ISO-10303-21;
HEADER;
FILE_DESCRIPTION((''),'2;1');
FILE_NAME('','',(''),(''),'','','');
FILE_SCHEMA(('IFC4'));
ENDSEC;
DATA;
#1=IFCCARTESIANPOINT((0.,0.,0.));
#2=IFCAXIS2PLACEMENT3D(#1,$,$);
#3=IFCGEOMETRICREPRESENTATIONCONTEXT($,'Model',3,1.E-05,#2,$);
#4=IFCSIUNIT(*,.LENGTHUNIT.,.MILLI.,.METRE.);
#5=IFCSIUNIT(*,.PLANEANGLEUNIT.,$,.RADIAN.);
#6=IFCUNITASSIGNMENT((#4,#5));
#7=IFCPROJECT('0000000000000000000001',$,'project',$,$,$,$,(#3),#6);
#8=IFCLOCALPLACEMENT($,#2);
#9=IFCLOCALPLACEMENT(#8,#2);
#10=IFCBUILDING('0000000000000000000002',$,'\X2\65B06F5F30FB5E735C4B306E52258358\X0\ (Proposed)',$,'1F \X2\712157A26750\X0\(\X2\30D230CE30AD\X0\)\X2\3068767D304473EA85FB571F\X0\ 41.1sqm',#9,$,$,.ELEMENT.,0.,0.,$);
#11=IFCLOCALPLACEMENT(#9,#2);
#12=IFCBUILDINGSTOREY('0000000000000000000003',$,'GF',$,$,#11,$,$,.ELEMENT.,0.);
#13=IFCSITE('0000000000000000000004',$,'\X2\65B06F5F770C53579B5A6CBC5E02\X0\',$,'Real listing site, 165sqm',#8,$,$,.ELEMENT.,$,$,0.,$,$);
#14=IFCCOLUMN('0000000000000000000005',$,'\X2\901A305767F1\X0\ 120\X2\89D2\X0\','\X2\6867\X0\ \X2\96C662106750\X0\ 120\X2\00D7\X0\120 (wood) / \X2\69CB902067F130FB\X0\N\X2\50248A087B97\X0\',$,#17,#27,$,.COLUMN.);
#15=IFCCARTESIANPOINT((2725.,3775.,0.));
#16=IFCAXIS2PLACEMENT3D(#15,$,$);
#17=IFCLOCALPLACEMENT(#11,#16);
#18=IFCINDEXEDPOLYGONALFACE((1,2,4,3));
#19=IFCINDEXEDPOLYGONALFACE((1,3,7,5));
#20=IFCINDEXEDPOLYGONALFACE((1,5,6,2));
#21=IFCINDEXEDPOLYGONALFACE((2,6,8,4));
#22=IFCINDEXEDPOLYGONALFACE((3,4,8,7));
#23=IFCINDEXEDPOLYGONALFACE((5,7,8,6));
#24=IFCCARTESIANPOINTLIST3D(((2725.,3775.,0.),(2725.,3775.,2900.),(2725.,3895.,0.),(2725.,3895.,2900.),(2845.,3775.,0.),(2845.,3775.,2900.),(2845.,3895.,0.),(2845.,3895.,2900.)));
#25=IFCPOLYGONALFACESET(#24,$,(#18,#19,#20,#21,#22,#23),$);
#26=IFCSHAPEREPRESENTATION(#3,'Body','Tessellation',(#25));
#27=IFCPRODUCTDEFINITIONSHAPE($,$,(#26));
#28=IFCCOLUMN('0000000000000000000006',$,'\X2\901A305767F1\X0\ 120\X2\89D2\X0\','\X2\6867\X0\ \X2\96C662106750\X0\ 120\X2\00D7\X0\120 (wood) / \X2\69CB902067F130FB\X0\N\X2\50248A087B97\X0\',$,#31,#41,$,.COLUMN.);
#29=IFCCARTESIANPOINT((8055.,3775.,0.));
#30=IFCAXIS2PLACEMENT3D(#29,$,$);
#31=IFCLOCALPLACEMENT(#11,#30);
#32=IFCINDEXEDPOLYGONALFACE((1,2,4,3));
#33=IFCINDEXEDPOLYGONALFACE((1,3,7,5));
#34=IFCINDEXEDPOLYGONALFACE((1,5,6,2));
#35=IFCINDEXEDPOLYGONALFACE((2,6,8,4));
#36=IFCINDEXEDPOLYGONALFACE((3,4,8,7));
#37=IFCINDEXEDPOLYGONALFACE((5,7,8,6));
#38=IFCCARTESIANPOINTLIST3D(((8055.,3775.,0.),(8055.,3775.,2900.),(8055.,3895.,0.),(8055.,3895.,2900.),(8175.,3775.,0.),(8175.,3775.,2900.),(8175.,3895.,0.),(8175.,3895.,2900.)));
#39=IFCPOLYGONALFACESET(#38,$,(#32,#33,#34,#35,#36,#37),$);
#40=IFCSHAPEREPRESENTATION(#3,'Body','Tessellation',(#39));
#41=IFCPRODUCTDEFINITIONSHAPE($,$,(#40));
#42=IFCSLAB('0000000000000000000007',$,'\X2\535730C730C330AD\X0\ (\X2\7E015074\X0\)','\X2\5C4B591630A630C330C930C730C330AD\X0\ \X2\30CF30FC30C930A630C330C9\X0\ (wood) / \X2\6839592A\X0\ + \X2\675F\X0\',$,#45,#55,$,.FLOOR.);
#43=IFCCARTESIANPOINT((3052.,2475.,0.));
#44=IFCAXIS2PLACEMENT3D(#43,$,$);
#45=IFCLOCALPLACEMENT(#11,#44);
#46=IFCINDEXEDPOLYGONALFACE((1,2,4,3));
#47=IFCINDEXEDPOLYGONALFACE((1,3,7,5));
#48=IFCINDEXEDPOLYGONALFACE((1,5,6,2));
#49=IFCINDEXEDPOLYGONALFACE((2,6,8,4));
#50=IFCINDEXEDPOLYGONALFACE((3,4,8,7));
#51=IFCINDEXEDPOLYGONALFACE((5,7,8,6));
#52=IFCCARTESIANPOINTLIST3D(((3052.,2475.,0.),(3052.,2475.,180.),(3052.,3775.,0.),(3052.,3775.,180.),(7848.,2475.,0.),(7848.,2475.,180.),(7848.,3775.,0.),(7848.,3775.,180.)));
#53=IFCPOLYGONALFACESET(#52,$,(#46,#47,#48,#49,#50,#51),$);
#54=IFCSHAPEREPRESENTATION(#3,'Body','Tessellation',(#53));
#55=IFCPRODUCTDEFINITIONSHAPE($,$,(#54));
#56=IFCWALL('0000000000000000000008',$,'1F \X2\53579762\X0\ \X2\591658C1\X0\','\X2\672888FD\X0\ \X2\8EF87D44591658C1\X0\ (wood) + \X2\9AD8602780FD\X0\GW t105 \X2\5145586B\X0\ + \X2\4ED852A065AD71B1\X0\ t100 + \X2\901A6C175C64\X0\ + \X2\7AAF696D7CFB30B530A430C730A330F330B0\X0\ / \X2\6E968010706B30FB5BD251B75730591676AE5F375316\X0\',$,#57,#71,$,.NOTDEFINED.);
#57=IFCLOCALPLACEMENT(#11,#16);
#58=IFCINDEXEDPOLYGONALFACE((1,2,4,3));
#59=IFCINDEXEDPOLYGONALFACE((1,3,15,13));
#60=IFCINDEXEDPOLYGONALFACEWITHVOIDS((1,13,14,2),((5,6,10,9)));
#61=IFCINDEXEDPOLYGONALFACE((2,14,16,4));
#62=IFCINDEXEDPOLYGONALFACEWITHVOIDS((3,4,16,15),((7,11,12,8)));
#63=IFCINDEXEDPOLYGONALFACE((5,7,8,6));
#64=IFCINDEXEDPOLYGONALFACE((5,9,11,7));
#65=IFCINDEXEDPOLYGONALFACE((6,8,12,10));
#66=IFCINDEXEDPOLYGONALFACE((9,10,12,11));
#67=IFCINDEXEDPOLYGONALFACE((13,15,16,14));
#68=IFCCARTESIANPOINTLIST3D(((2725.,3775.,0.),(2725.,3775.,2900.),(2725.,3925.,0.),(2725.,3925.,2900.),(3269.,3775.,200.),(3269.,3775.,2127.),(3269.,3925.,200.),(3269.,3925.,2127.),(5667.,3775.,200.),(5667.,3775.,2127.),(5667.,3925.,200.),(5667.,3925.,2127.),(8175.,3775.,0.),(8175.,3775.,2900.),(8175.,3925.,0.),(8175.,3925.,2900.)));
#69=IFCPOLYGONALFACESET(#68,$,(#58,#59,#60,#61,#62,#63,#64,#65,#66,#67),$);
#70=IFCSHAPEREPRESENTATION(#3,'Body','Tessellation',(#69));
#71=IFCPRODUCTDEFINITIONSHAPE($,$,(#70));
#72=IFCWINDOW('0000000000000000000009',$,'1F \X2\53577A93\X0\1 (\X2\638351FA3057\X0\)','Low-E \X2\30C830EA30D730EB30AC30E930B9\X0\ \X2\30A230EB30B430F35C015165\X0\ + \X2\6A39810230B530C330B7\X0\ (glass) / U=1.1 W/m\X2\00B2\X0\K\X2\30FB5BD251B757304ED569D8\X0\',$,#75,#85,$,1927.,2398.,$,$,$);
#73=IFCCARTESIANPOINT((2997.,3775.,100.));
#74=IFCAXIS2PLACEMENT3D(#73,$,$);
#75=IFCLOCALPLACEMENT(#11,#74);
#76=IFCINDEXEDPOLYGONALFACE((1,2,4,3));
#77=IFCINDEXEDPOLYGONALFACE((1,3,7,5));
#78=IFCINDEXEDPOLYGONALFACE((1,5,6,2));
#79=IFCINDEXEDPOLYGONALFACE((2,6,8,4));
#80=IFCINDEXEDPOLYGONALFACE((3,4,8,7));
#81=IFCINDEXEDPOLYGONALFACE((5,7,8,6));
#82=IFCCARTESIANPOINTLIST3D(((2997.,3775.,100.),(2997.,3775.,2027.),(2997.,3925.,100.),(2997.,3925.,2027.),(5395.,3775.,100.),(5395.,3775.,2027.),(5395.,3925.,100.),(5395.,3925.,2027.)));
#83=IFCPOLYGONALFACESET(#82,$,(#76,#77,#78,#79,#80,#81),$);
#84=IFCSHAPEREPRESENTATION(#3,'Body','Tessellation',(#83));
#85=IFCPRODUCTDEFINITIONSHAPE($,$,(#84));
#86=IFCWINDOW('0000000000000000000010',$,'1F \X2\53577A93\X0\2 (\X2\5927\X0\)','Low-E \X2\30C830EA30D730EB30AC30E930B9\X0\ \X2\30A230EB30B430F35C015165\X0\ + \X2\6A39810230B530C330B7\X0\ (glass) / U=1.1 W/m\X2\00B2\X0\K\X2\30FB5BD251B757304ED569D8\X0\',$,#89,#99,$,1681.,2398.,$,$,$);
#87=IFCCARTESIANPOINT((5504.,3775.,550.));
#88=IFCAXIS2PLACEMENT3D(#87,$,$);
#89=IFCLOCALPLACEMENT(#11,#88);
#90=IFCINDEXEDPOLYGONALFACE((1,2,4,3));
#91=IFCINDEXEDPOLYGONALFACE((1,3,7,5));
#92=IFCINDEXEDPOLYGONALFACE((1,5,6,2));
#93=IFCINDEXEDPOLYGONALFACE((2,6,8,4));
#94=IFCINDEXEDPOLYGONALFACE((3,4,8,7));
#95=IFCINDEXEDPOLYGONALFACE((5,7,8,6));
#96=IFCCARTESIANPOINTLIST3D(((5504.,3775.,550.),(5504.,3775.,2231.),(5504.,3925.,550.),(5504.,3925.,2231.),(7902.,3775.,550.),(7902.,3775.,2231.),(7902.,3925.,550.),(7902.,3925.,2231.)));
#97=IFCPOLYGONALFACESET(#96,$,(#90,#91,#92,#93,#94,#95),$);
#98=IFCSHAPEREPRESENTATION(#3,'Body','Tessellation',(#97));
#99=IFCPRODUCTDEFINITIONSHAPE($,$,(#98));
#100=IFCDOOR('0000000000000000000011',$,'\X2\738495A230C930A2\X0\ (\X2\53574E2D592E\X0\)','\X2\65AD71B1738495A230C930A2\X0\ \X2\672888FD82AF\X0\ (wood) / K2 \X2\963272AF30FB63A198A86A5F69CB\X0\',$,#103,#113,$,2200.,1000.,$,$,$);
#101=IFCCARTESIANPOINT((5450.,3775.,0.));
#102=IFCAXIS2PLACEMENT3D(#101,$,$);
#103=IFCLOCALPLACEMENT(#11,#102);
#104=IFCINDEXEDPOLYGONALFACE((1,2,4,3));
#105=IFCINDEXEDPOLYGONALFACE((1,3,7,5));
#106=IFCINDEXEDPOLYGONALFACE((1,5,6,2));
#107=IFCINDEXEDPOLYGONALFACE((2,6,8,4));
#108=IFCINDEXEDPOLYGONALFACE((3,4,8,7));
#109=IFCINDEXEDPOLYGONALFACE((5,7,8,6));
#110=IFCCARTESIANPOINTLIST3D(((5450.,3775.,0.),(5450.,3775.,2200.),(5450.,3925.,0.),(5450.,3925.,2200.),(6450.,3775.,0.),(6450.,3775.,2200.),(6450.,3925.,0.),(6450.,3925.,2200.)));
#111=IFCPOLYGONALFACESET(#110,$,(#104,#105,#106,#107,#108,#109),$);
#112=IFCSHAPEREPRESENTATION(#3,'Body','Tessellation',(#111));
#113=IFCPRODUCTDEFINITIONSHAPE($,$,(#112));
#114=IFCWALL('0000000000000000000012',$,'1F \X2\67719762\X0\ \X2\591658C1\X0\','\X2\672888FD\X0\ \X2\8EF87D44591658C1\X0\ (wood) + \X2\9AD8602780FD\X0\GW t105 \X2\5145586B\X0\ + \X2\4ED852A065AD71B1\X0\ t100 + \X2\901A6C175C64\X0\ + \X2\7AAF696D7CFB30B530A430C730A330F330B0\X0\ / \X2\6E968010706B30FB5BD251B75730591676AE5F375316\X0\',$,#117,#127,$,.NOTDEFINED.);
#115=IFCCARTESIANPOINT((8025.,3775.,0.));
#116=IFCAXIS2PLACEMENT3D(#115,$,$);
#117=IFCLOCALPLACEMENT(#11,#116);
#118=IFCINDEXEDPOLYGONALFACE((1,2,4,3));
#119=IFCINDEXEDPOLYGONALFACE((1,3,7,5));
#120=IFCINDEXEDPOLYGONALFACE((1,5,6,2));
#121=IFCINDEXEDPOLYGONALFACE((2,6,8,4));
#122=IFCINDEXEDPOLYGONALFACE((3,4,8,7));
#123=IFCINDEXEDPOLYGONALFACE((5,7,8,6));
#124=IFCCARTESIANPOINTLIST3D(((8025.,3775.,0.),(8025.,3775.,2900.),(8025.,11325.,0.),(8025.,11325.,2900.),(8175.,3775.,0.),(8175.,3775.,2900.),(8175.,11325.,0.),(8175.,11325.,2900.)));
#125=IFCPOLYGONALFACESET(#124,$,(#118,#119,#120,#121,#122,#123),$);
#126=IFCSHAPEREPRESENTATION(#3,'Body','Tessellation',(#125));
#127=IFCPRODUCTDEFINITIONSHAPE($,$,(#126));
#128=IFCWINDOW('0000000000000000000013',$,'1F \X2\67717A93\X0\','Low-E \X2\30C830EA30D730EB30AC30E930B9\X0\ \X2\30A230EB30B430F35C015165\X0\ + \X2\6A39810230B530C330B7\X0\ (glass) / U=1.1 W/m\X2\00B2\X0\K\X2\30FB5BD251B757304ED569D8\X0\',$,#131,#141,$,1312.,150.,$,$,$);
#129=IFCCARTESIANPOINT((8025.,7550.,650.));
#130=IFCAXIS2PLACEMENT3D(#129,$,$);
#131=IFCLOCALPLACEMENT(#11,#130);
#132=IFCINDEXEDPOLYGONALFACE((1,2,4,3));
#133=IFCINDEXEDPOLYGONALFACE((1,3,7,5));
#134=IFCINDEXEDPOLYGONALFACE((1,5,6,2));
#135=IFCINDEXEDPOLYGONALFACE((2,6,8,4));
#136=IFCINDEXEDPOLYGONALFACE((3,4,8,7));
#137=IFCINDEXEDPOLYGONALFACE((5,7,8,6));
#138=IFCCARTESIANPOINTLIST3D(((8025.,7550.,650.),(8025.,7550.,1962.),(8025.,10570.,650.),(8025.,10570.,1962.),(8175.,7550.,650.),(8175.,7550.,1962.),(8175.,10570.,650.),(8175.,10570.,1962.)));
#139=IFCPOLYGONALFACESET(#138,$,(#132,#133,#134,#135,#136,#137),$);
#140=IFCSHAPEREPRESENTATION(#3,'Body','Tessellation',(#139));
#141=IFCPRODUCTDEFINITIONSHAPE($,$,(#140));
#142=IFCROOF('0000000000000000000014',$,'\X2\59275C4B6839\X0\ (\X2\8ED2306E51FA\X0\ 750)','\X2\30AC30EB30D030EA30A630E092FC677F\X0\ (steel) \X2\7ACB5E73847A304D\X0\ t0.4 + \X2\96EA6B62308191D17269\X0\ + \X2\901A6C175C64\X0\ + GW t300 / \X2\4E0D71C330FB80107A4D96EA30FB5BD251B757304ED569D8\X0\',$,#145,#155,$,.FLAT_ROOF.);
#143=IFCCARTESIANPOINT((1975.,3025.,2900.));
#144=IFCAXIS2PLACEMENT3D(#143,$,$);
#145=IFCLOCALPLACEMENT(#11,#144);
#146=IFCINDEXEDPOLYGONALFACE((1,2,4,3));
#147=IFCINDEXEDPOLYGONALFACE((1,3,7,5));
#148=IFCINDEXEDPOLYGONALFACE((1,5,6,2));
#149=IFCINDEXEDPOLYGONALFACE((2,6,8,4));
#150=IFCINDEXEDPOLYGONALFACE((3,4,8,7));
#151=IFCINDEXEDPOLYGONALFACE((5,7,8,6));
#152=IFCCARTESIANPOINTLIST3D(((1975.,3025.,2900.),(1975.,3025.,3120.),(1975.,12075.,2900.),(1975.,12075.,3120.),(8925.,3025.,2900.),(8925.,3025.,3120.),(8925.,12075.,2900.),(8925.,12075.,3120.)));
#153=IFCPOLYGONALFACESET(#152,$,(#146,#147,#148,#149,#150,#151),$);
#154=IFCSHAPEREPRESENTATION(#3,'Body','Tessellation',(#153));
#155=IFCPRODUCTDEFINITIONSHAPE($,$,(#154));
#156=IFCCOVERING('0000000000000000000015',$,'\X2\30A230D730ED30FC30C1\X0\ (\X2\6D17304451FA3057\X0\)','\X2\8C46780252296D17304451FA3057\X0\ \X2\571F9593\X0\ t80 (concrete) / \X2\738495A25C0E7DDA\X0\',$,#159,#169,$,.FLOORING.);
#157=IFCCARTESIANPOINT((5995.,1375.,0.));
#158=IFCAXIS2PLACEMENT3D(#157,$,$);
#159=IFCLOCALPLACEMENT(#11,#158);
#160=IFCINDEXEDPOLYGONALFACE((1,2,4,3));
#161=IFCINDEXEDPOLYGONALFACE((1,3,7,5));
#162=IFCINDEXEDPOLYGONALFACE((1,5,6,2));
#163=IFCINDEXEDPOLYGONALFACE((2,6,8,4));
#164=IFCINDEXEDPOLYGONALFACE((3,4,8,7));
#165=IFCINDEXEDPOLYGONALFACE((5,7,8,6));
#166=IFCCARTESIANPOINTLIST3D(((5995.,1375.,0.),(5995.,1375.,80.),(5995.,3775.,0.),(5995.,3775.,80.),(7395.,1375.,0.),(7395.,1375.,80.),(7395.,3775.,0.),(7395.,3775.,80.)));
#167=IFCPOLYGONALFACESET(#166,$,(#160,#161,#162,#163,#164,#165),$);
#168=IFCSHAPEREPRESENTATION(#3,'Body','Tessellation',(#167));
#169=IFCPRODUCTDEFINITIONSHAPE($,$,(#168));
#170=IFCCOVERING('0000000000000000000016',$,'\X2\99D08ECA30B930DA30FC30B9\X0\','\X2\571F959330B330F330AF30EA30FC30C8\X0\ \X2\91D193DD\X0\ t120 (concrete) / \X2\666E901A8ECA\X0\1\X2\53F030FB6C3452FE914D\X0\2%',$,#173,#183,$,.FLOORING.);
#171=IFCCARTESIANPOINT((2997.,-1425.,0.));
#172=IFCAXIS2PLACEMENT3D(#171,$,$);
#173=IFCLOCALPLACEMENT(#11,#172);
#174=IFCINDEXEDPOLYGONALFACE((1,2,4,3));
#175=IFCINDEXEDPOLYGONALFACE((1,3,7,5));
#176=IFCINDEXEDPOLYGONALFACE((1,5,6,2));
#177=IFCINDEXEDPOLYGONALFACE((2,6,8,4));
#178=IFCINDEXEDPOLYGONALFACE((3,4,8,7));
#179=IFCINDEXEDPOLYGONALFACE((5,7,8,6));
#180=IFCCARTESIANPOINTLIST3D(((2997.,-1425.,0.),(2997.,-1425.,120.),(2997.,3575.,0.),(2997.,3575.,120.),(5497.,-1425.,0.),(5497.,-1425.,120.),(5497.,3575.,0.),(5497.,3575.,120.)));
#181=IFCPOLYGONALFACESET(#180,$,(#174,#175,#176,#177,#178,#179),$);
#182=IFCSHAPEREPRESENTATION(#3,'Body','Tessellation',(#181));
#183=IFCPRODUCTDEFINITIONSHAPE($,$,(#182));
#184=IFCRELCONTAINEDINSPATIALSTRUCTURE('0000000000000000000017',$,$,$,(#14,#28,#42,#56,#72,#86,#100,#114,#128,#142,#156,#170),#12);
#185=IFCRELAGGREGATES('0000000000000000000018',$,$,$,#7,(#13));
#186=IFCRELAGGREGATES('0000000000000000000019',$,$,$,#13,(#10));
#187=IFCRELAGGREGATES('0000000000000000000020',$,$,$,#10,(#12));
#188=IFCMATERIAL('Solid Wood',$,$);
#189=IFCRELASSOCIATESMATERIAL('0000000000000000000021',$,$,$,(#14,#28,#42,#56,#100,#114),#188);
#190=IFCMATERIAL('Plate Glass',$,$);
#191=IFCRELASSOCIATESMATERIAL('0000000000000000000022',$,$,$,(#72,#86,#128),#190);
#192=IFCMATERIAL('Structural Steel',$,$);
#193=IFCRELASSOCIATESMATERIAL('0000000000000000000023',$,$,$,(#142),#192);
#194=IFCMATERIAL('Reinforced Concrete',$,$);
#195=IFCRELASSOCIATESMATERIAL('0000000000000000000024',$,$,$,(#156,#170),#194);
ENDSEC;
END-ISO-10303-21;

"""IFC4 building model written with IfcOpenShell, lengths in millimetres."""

from ifc_helpers import new_model, si_unit, frame, frame_2d, origin, place, context, project, spatial, rectangle, extrude, material, element, fill, save


model = new_model("IFC4")

# Units and contexts
model_context = context("Model", 3, precision=1e-05, world=origin())
ifc_project = project(units=[si_unit("LENGTHUNIT", "METRE", prefix="MILLI"), si_unit("PLANEANGLEUNIT", "RADIAN")], contexts=[model_context])

# Site, building, storey
site_placement = place(None, origin())
site = spatial("IfcSite", under=ifc_project, at=site_placement, Name="新潟県南魚沼市", ObjectType="Real listing site, 165sqm", CompositionType="ELEMENT", RefElevation=0.0)
building_placement = place(site_placement, origin())
building = spatial("IfcBuilding", under=site, at=building_placement, Name="新潟・平屋の別荘 (Proposed)", ObjectType="1F 無垢材(ヒノキ)と白い珪藻土 41.1sqm", CompositionType="ELEMENT", ElevationOfRefHeight=0.0, ElevationOfTerrain=0.0)
storey_placement = place(building_placement, origin())
storey = spatial("IfcBuildingStorey", under=building, at=storey_placement, Name="GF", CompositionType="ELEMENT", Elevation=0.0)

# Columns
ifc_material_1 = material(Name="Solid Wood")
column_1_placement = place(storey_placement, frame((2725.0, 3775.0, 0.0)))
element("IfcColumn", 1, at=column_1_placement, inside=storey, material=ifc_material_1, Name="通し柱 120角", Description="桧 集成材 120×120 (wood) / 構造柱・N値計算", PredefinedType="COLUMN", context=model_context, shape_type="SweptSolid", body=[
    extrude(rectangle(XDim=120.0, YDim=120.0, at=frame_2d((60.0, 60.0))), frame((2725.0, 3775.0, 0.0)), (0.0, 0.0, 1.0), 2900.0),
])
column_2_placement = place(storey_placement, frame((8055.0, 3775.0, 0.0)))
element("IfcColumn", 2, at=column_2_placement, inside=storey, material=ifc_material_1, Name="通し柱 120角", Description="桧 集成材 120×120 (wood) / 構造柱・N値計算", PredefinedType="COLUMN", context=model_context, shape_type="SweptSolid", body=[
    extrude(rectangle(XDim=120.0, YDim=120.0, at=frame_2d((60.0, 60.0))), frame((8055.0, 3775.0, 0.0)), (0.0, 0.0, 1.0), 2900.0),
])

# Slab
ifc_material_2 = material(Name="Reinforced Concrete")
slab_1_placement = place(storey_placement, frame((3052.0, 2475.0, 0.0)))
element("IfcSlab", 3, at=slab_1_placement, inside=storey, material=ifc_material_1, Name="南デッキ (縁側)", Description="屋外ウッドデッキ ハードウッド (wood) / 根太 + 束", PredefinedType="FLOOR", context=model_context, shape_type="SweptSolid", body=[
    extrude(rectangle(XDim=4796.0, YDim=1300.0, at=frame_2d((2398.0, 650.0))), frame((3052.0, 2475.0, 0.0)), (0.0, 0.0, 1.0), 180.0),
])

# Wall, openings, windows, door
wall_1_placement = place(storey_placement, frame((2725.0, 3775.0, 0.0)))
wall_1 = element("IfcWall", 4, at=wall_1_placement, inside=storey, material=ifc_material_1, Name="1F 南面 外壁", Description="木製 軸組外壁 (wood) + 高性能GW t105 充填 + 付加断熱 t100 + 通気層 + 窯業系サイディング / 準耐火・寒冷地外皮強化", PredefinedType="NOTDEFINED", context=model_context, shape_type="SweptSolid", body=[
    extrude(rectangle(XDim=5450.0, YDim=150.0, at=frame_2d((2725.0, 75.0))), frame((2725.0, 3775.0, 0.0)), (0.0, 0.0, 1.0), 2900.0),
])
opening_1_placement = place(storey_placement, frame((2997.0, 3775.0, 100.0)))
opening_1 = element("IfcOpeningElement", 5, at=opening_1_placement, cuts=wall_1, PredefinedType="NOTDEFINED", context=model_context, shape_type="SweptSolid", body=[
    extrude(rectangle(XDim=2398.0, YDim=150.0, at=frame_2d((1199.0, 75.0))), frame((2997.0, 3775.0, 100.0)), (0.0, 0.0, 1.0), 1927.0),
])
opening_2_placement = place(storey_placement, frame((5504.0, 3775.0, 550.0)))
opening_2 = element("IfcOpeningElement", 6, at=opening_2_placement, cuts=wall_1, PredefinedType="NOTDEFINED", context=model_context, shape_type="SweptSolid", body=[
    extrude(rectangle(XDim=2398.0, YDim=150.0, at=frame_2d((1199.0, 75.0))), frame((5504.0, 3775.0, 550.0)), (0.0, 0.0, 1.0), 1681.0),
])
opening_3_placement = place(storey_placement, frame((5450.0, 3775.0, 0.0)))
opening_3 = element("IfcOpeningElement", 7, at=opening_3_placement, cuts=wall_1, PredefinedType="NOTDEFINED", context=model_context, shape_type="SweptSolid", body=[
    extrude(rectangle(XDim=1000.0, YDim=150.0, at=frame_2d((500.0, 75.0))), frame((5450.0, 3775.0, 0.0)), (0.0, 0.0, 1.0), 2200.0),
])
ifc_material_3 = material(Name="Plate Glass")
window_1_placement = place(storey_placement, frame((2997.0, 3775.0, 100.0)))
window_1 = element("IfcWindow", 8, at=window_1_placement, inside=storey, material=ifc_material_3, Name="1F 南窓1 (掃出し)", Description="Low-E トリプルガラス アルゴン封入 + 樹脂サッシ (glass) / U=1.1 W/m²K・寒冷地仕様", OverallHeight=1927.0, OverallWidth=2398.0, context=model_context, shape_type="SweptSolid", body=[
    extrude(rectangle(XDim=2398.0, YDim=150.0, at=frame_2d((1199.0, 75.0))), frame((2997.0, 3775.0, 100.0)), (0.0, 0.0, 1.0), 1927.0),
])
fill(opening_1, window_1)
window_2_placement = place(storey_placement, frame((5504.0, 3775.0, 550.0)))
window_2 = element("IfcWindow", 9, at=window_2_placement, inside=storey, material=ifc_material_3, Name="1F 南窓2 (大)", Description="Low-E トリプルガラス アルゴン封入 + 樹脂サッシ (glass) / U=1.1 W/m²K・寒冷地仕様", OverallHeight=1681.0, OverallWidth=2398.0, context=model_context, shape_type="SweptSolid", body=[
    extrude(rectangle(XDim=2398.0, YDim=150.0, at=frame_2d((1199.0, 75.0))), frame((5504.0, 3775.0, 550.0)), (0.0, 0.0, 1.0), 1681.0),
])
fill(opening_2, window_2)
door_placement = place(storey_placement, frame((5450.0, 3775.0, 0.0)))
door = element("IfcDoor", 10, at=door_placement, inside=storey, material=ifc_material_1, Name="玄関ドア (南中央)", Description="断熱玄関ドア 木製芯 (wood) / K2 防犯・採風機構", OverallHeight=2200.0, OverallWidth=1000.0, context=model_context, shape_type="SweptSolid", body=[
    extrude(rectangle(XDim=1000.0, YDim=150.0, at=frame_2d((500.0, 75.0))), frame((5450.0, 3775.0, 0.0)), (0.0, 0.0, 1.0), 2200.0),
])
fill(opening_3, door)

# Wall, opening, window
wall_2_placement = place(storey_placement, frame((8025.0, 3775.0, 0.0)))
wall_2 = element("IfcWall", 11, at=wall_2_placement, inside=storey, material=ifc_material_1, Name="1F 東面 外壁", Description="木製 軸組外壁 (wood) + 高性能GW t105 充填 + 付加断熱 t100 + 通気層 + 窯業系サイディング / 準耐火・寒冷地外皮強化", PredefinedType="NOTDEFINED", context=model_context, shape_type="SweptSolid", body=[
    extrude(rectangle(XDim=150.0, YDim=7550.0, at=frame_2d((75.0, 3775.0))), frame((8025.0, 3775.0, 0.0)), (0.0, 0.0, 1.0), 2900.0),
])
opening_4_placement = place(storey_placement, frame((8025.0, 7550.0, 650.0)))
opening_4 = element("IfcOpeningElement", 12, at=opening_4_placement, cuts=wall_2, PredefinedType="NOTDEFINED", context=model_context, shape_type="SweptSolid", body=[
    extrude(rectangle(XDim=150.0, YDim=3020.0, at=frame_2d((75.0, 1510.0))), frame((8025.0, 7550.0, 650.0)), (0.0, 0.0, 1.0), 1312.0),
])
window_3_placement = place(storey_placement, frame((8025.0, 7550.0, 650.0)))
window_3 = element("IfcWindow", 13, at=window_3_placement, inside=storey, material=ifc_material_3, Name="1F 東窓", Description="Low-E トリプルガラス アルゴン封入 + 樹脂サッシ (glass) / U=1.1 W/m²K・寒冷地仕様", OverallHeight=1312.0, OverallWidth=150.0, context=model_context, shape_type="SweptSolid", body=[
    extrude(rectangle(XDim=150.0, YDim=3020.0, at=frame_2d((75.0, 1510.0))), frame((8025.0, 7550.0, 650.0)), (0.0, 0.0, 1.0), 1312.0),
])
fill(opening_4, window_3)

# Roof
ifc_material_4 = material(Name="Structural Steel")
roof_placement = place(storey_placement, frame((1975.0, 3025.0, 2900.0)))
element("IfcRoof", 14, at=roof_placement, inside=storey, material=ifc_material_4, Name="大屋根 (軒の出 750)", Description="ガルバリウム鋼板 (steel) 立平葺き t0.4 + 雪止め金物 + 通気層 + GW t300 / 不燃・耐積雪・寒冷地仕様", PredefinedType="FLAT_ROOF", context=model_context, shape_type="SweptSolid", body=[
    extrude(rectangle(XDim=6950.0, YDim=9050.0, at=frame_2d((3475.0, 4525.0))), frame((1975.0, 3025.0, 2900.0)), (0.0, 0.0, 1.0), 220.0),
])

# Coverings
covering_1_placement = place(storey_placement, frame((5995.0, 1375.0, 0.0)))
element("IfcCovering", 15, at=covering_1_placement, inside=storey, material=ifc_material_2, Name="アプローチ (洗い出し)", Description="豆砂利洗い出し 土間 t80 (concrete) / 玄関導線", PredefinedType="FLOORING", context=model_context, shape_type="SweptSolid", body=[
    extrude(rectangle(XDim=1400.0, YDim=2400.0, at=frame_2d((700.0, 1200.0))), frame((5995.0, 1375.0, 0.0)), (0.0, 0.0, 1.0), 80.0),
])
covering_2_placement = place(storey_placement, frame((2997.0, -1425.0, 0.0)))
element("IfcCovering", 16, at=covering_2_placement, inside=storey, material=ifc_material_2, Name="駐車スペース", Description="土間コンクリート 金鏝 t120 (concrete) / 普通車1台・水勾配2%", PredefinedType="FLOORING", context=model_context, shape_type="SweptSolid", body=[
    extrude(rectangle(XDim=2500.0, YDim=5000.0, at=frame_2d((1250.0, 2500.0))), frame((2997.0, -1425.0, 0.0)), (0.0, 0.0, 1.0), 120.0),
])

save(model, "model.ifc")
